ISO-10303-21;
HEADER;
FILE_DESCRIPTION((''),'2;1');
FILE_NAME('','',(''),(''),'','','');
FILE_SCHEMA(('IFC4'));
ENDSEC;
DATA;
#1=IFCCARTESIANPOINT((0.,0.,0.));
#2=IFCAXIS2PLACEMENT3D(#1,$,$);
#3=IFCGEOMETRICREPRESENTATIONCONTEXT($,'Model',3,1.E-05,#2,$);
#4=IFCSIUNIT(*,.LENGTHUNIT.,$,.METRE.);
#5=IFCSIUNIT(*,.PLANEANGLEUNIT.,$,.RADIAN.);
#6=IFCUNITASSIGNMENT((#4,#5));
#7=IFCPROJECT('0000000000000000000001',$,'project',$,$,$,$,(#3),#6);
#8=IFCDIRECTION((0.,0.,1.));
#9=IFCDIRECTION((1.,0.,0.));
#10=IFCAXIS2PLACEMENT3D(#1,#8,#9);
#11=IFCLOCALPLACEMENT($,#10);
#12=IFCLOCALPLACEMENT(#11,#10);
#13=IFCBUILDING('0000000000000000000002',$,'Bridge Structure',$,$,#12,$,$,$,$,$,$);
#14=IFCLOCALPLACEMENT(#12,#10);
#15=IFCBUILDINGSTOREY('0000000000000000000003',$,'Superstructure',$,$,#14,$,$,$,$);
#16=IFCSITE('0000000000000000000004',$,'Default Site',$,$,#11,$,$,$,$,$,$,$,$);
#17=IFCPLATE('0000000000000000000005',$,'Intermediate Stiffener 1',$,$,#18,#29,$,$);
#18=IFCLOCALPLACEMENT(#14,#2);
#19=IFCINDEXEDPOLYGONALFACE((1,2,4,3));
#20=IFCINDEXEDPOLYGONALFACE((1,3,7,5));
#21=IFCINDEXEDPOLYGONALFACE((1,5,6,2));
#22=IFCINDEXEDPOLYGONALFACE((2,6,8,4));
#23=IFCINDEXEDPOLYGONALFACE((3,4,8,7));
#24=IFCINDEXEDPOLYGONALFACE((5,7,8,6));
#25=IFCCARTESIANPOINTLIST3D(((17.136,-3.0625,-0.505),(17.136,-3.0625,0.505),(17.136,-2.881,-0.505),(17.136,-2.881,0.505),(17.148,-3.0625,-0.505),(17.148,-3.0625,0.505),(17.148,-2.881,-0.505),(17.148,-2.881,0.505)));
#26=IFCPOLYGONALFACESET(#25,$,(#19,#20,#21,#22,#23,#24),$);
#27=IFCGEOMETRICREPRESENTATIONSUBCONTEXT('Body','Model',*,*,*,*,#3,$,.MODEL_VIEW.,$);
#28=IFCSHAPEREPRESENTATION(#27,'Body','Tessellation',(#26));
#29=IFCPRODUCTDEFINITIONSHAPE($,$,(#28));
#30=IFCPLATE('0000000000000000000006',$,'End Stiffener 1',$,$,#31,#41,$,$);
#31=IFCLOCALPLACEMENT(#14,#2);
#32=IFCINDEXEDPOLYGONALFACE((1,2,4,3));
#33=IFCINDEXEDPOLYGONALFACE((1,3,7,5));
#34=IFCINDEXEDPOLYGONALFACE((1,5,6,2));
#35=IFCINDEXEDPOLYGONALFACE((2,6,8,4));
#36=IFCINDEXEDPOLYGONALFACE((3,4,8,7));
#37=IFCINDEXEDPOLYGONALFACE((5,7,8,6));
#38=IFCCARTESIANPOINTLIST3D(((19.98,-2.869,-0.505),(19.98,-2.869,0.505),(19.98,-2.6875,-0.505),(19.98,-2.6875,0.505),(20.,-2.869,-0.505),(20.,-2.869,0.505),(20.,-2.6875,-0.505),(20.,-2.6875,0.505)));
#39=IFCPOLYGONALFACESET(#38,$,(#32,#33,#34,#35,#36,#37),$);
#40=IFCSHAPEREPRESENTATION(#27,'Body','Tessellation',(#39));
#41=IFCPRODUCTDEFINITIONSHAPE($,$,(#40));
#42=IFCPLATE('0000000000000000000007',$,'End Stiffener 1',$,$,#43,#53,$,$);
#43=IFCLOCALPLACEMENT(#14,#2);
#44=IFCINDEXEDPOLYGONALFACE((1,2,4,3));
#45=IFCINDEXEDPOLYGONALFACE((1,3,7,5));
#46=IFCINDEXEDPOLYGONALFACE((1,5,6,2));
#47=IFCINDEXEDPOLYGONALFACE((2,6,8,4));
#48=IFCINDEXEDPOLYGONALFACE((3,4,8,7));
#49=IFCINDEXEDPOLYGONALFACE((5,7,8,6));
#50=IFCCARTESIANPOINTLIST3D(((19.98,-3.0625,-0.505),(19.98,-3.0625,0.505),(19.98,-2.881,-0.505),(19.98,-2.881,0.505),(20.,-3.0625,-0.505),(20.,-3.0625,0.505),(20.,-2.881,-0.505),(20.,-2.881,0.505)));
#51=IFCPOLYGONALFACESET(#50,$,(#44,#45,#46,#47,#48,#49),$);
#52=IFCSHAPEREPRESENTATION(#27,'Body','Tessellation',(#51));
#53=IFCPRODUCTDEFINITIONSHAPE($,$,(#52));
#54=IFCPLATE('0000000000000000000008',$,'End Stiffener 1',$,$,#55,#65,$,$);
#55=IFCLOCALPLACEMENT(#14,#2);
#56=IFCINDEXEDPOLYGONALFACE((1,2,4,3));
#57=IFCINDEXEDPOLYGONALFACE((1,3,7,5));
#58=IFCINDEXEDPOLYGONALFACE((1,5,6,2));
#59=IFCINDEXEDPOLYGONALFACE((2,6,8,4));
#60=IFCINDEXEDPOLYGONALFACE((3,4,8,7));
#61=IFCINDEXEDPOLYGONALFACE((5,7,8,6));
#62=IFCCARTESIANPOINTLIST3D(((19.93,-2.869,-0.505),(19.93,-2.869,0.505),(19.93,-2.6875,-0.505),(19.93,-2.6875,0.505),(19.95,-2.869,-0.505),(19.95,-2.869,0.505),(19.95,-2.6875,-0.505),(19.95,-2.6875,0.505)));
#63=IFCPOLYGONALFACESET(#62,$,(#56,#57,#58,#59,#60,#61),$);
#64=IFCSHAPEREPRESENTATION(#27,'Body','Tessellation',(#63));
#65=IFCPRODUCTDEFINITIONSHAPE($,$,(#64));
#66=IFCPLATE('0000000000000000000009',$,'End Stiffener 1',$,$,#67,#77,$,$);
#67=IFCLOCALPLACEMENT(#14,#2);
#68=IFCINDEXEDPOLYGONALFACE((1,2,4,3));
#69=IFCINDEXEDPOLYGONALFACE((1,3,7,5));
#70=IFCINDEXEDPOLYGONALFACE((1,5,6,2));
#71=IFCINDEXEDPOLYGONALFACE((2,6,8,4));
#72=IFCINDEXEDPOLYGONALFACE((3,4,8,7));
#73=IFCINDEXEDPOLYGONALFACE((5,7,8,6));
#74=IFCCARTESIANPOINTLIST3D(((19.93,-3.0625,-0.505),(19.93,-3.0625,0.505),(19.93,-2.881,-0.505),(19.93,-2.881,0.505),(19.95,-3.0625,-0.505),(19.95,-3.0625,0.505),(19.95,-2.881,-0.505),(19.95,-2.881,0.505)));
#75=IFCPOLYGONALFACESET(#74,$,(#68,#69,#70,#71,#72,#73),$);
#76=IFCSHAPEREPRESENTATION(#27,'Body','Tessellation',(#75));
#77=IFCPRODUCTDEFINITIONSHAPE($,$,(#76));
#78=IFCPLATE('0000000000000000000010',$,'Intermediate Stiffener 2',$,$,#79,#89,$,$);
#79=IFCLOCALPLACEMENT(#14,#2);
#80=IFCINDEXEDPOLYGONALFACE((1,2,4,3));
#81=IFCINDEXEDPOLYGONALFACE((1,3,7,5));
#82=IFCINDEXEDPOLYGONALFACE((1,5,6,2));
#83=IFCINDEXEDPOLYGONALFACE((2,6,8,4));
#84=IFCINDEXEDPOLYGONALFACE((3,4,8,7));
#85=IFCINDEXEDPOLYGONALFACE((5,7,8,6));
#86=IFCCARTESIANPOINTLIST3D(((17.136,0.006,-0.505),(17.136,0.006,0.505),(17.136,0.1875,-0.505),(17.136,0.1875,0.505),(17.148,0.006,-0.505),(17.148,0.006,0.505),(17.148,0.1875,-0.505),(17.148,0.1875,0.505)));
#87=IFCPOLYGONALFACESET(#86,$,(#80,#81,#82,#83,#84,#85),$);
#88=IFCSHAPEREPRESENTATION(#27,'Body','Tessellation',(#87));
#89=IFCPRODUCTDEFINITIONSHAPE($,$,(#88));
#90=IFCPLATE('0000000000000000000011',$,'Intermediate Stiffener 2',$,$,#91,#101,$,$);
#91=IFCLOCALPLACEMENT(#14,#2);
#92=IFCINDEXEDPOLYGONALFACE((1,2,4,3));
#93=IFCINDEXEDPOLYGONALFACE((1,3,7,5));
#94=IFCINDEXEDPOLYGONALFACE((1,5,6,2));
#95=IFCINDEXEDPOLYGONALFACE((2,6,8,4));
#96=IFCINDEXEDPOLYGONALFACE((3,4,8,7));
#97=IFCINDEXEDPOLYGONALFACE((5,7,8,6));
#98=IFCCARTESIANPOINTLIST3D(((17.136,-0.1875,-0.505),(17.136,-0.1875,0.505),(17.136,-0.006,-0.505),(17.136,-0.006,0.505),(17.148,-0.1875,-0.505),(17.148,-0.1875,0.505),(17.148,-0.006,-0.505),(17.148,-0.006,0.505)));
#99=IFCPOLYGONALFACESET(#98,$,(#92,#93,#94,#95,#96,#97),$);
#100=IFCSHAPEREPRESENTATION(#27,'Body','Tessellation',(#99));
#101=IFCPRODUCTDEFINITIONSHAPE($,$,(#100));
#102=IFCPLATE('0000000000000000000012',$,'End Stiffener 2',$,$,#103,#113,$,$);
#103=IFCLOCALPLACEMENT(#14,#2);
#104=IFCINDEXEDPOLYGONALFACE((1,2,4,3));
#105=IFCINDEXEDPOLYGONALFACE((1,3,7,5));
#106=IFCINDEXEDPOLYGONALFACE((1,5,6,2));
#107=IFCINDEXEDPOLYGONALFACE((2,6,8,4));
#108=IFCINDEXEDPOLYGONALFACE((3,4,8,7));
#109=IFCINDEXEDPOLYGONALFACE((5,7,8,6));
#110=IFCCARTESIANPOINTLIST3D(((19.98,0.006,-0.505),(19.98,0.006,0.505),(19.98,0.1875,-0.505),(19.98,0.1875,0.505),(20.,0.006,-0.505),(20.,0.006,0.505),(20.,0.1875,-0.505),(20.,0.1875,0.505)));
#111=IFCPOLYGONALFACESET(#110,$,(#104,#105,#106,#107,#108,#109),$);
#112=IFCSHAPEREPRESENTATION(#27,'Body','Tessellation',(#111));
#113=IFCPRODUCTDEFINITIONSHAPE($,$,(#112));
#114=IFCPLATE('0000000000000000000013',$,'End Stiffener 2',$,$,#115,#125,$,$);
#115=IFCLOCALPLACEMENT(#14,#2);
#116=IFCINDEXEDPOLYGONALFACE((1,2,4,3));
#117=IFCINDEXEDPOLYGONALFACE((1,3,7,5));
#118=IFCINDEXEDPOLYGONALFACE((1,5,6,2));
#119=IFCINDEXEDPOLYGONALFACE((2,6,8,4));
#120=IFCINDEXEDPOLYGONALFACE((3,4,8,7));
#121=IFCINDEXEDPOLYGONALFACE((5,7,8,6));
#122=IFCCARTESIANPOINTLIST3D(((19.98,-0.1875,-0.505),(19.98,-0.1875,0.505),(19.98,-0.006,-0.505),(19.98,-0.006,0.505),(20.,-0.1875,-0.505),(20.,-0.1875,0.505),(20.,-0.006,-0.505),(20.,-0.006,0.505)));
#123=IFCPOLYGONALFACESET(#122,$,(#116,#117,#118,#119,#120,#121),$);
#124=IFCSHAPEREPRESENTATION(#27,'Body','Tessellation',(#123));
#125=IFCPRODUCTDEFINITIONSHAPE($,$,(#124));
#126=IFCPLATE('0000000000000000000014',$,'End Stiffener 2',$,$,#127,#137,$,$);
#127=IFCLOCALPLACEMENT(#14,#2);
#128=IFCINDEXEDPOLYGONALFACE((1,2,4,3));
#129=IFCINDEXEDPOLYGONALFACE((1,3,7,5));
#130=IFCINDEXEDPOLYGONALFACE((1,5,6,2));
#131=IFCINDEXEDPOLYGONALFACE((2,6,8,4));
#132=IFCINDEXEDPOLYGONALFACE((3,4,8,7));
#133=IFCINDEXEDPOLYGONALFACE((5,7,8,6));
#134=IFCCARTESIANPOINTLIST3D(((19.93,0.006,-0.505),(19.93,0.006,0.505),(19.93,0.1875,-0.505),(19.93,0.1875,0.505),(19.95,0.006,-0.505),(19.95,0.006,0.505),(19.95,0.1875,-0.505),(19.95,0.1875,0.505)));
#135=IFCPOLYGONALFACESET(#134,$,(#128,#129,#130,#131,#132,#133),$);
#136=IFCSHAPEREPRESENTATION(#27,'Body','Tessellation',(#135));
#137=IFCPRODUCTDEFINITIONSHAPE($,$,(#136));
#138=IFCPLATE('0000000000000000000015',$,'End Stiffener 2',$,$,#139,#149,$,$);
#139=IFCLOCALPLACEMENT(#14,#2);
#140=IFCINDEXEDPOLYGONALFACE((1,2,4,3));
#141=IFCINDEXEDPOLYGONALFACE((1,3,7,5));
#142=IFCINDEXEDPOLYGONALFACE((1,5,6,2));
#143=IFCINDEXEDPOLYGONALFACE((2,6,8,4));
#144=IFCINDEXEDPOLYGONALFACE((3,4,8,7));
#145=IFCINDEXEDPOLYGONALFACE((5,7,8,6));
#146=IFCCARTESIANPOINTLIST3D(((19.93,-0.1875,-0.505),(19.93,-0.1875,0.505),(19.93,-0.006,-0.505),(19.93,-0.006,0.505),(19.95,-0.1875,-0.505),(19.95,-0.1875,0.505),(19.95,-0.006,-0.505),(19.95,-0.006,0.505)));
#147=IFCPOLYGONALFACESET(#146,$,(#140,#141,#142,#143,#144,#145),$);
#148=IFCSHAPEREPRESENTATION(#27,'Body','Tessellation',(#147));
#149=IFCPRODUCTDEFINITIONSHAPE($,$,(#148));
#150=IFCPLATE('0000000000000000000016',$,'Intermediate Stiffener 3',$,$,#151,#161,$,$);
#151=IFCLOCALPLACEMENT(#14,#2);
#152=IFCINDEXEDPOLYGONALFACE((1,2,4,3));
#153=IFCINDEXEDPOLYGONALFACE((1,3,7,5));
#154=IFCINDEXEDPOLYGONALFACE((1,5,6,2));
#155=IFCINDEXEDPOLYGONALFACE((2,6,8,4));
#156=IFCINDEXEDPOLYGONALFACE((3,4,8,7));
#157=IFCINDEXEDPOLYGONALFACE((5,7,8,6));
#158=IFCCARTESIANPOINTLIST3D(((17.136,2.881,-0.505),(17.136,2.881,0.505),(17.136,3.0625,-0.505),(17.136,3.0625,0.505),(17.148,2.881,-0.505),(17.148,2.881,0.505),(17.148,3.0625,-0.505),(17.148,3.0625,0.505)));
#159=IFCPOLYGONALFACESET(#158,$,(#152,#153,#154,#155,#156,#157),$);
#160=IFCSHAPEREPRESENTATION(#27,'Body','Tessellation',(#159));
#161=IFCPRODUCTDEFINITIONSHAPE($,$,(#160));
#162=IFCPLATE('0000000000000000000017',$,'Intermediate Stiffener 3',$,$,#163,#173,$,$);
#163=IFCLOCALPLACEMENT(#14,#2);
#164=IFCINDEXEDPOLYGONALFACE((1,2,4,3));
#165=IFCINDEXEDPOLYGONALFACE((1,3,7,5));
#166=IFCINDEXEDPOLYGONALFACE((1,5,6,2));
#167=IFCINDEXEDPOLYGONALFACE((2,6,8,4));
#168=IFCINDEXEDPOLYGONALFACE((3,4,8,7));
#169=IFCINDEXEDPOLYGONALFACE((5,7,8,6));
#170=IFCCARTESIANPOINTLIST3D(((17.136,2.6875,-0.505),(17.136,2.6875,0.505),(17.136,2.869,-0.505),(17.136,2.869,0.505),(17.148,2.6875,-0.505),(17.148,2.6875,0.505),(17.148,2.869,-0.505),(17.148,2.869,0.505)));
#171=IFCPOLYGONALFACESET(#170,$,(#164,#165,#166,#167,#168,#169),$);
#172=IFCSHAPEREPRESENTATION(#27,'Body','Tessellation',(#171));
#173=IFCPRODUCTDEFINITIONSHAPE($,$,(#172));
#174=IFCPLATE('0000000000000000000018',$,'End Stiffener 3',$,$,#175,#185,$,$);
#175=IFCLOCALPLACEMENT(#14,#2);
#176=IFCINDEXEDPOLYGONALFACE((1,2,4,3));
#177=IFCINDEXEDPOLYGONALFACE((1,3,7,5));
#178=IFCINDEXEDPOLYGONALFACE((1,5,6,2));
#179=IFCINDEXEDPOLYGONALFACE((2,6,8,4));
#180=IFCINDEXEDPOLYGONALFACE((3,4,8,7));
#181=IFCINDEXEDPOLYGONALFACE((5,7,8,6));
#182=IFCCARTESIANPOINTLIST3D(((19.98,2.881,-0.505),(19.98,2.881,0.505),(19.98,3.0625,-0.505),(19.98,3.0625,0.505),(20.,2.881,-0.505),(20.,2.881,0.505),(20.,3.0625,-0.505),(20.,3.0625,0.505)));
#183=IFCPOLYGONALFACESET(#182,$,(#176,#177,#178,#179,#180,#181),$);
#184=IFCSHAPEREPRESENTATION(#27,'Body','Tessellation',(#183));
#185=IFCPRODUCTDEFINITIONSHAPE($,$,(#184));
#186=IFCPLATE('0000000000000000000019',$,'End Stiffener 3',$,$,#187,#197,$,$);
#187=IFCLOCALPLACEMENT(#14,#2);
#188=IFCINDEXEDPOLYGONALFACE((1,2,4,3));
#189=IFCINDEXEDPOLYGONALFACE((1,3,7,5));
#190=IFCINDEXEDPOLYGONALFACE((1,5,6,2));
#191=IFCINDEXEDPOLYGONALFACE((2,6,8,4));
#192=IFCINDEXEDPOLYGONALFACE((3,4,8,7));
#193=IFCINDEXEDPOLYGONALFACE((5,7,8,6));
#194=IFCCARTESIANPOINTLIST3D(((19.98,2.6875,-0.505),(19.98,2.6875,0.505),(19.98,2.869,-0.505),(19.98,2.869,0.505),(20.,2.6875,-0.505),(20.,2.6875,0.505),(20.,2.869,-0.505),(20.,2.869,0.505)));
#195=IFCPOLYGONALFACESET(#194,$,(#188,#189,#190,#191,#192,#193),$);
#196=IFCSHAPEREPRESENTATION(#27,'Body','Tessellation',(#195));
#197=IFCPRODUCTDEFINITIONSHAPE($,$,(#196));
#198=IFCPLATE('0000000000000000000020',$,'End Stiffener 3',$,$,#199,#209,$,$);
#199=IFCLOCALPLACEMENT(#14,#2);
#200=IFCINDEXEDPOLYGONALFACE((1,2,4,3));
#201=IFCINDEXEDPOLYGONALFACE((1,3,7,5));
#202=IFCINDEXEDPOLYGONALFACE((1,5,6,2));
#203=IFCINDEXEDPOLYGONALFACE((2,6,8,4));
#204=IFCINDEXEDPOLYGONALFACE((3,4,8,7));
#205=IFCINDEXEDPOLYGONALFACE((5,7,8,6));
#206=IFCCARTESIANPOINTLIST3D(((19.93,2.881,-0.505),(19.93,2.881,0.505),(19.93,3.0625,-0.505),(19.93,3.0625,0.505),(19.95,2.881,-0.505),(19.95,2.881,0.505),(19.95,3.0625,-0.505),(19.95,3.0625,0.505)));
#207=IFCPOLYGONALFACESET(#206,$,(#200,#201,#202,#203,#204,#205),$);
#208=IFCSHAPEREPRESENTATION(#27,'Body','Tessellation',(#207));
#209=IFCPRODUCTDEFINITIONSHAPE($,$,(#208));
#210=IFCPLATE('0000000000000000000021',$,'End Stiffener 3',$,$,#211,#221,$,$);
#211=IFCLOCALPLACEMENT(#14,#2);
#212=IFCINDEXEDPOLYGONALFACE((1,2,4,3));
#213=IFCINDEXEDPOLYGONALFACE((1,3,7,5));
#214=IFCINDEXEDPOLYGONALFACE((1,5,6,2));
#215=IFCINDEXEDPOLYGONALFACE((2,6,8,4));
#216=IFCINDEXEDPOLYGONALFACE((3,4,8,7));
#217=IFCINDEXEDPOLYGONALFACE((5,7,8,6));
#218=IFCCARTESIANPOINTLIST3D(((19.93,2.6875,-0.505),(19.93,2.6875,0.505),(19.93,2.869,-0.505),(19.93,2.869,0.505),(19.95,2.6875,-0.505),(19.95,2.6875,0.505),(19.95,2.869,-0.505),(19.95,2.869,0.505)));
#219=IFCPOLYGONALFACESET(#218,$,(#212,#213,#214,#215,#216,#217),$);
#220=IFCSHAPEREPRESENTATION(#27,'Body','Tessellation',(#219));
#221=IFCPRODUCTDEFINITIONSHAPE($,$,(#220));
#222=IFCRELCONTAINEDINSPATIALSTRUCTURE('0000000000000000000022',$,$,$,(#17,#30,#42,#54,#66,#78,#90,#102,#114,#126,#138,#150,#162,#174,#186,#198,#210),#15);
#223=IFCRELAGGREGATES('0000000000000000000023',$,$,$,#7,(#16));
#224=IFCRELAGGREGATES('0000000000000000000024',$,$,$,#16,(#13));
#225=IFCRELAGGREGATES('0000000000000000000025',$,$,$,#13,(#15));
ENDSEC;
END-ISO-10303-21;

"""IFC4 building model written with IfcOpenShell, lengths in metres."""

from ifc_helpers import new_model, si_unit, frame, origin, origin_with_axes, origin_2d_with_axis, place, context, subcontext, project, spatial, rectangle, extrude, element, save


model = new_model("IFC4")

# Units and contexts
model_context = context("Model", 3, precision=1e-05, world=origin())
body_context = subcontext(model_context, "Body", "Model", "MODEL_VIEW")
ifc_project = project(units=[si_unit("LENGTHUNIT", "METRE"), si_unit("PLANEANGLEUNIT", "RADIAN")], contexts=[model_context])

# Site, building, storey
site_placement = place(None, origin_with_axes())
site = spatial("IfcSite", under=ifc_project, at=site_placement, Name="Default Site")
building_placement = place(site_placement, origin_with_axes())
building = spatial("IfcBuilding", under=site, at=building_placement, Name="Bridge Structure")
storey_placement = place(building_placement, origin_with_axes())
storey = spatial("IfcBuildingStorey", under=building, at=storey_placement, Name="Superstructure")

# Plates
for number, where, z_axis, x_axis, name in (
    (1, (17.142, -2.9718, -0.505), (0.0, 0.0, 1.0), (1.0, 0.0, 0.0), "Intermediate Stiffener 1"),
):
    element("IfcPlate", number, at=place(storey_placement, frame(where, z_axis=z_axis, x_axis=x_axis)), inside=storey, Name=name, context=body_context, shape_type="SweptSolid", body=[
        extrude(rectangle(XDim=0.012, YDim=0.1815, at=origin_2d_with_axis()), origin_with_axes(), (0.0, 0.0, 1.0), 1.01),
    ])
for number, where, z_axis, x_axis, name in (
    (2, (19.99, -2.7782, -0.505), (0.0, 0.0, 1.0), (1.0, 0.0, 0.0), "End Stiffener 1"),
    (3, (19.99, -2.9718, -0.505), (0.0, 0.0, 1.0), (1.0, 0.0, 0.0), "End Stiffener 1"),
    (4, (19.94, -2.7782, -0.505), (0.0, 0.0, 1.0), (1.0, 0.0, 0.0), "End Stiffener 1"),
    (5, (19.94, -2.9718, -0.505), (0.0, 0.0, 1.0), (1.0, 0.0, 0.0), "End Stiffener 1"),
):
    element("IfcPlate", number, at=place(storey_placement, frame(where, z_axis=z_axis, x_axis=x_axis)), inside=storey, Name=name, context=body_context, shape_type="SweptSolid", body=[
        extrude(rectangle(XDim=0.02, YDim=0.1815, at=origin_2d_with_axis()), origin_with_axes(), (0.0, 0.0, 1.0), 1.01),
    ])
for number, where, z_axis, x_axis, name in (
    (6, (17.142, 0.0968, -0.505), (0.0, 0.0, 1.0), (1.0, 0.0, 0.0), "Intermediate Stiffener 2"),
    (7, (17.142, -0.0968, -0.505), (0.0, 0.0, 1.0), (1.0, 0.0, 0.0), "Intermediate Stiffener 2"),
):
    element("IfcPlate", number, at=place(storey_placement, frame(where, z_axis=z_axis, x_axis=x_axis)), inside=storey, Name=name, context=body_context, shape_type="SweptSolid", body=[
        extrude(rectangle(XDim=0.012, YDim=0.1815, at=origin_2d_with_axis()), origin_with_axes(), (0.0, 0.0, 1.0), 1.01),
    ])
for number, where, z_axis, x_axis, name in (
    (8, (19.99, 0.0968, -0.505), (0.0, 0.0, 1.0), (1.0, 0.0, 0.0), "End Stiffener 2"),
    (9, (19.99, -0.0968, -0.505), (0.0, 0.0, 1.0), (1.0, 0.0, 0.0), "End Stiffener 2"),
    (10, (19.94, 0.0968, -0.505), (0.0, 0.0, 1.0), (1.0, 0.0, 0.0), "End Stiffener 2"),
    (11, (19.94, -0.0968, -0.505), (0.0, 0.0, 1.0), (1.0, 0.0, 0.0), "End Stiffener 2"),
):
    element("IfcPlate", number, at=place(storey_placement, frame(where, z_axis=z_axis, x_axis=x_axis)), inside=storey, Name=name, context=body_context, shape_type="SweptSolid", body=[
        extrude(rectangle(XDim=0.02, YDim=0.1815, at=origin_2d_with_axis()), origin_with_axes(), (0.0, 0.0, 1.0), 1.01),
    ])
for number, where, z_axis, x_axis, name in (
    (12, (17.142, 2.9718, -0.505), (0.0, 0.0, 1.0), (1.0, 0.0, 0.0), "Intermediate Stiffener 3"),
    (13, (17.142, 2.7782, -0.505), (0.0, 0.0, 1.0), (1.0, 0.0, 0.0), "Intermediate Stiffener 3"),
):
    element("IfcPlate", number, at=place(storey_placement, frame(where, z_axis=z_axis, x_axis=x_axis)), inside=storey, Name=name, context=body_context, shape_type="SweptSolid", body=[
        extrude(rectangle(XDim=0.012, YDim=0.1815, at=origin_2d_with_axis()), origin_with_axes(), (0.0, 0.0, 1.0), 1.01),
    ])
for number, where, z_axis, x_axis, name in (
    (14, (19.99, 2.9718, -0.505), (0.0, 0.0, 1.0), (1.0, 0.0, 0.0), "End Stiffener 3"),
    (15, (19.99, 2.7782, -0.505), (0.0, 0.0, 1.0), (1.0, 0.0, 0.0), "End Stiffener 3"),
    (16, (19.94, 2.9718, -0.505), (0.0, 0.0, 1.0), (1.0, 0.0, 0.0), "End Stiffener 3"),
    (17, (19.94, 2.7782, -0.505), (0.0, 0.0, 1.0), (1.0, 0.0, 0.0), "End Stiffener 3"),
):
    element("IfcPlate", number, at=place(storey_placement, frame(where, z_axis=z_axis, x_axis=x_axis)), inside=storey, Name=name, context=body_context, shape_type="SweptSolid", body=[
        extrude(rectangle(XDim=0.02, YDim=0.1815, at=origin_2d_with_axis()), origin_with_axes(), (0.0, 0.0, 1.0), 1.01),
    ])

save(model, "model.ifc")
